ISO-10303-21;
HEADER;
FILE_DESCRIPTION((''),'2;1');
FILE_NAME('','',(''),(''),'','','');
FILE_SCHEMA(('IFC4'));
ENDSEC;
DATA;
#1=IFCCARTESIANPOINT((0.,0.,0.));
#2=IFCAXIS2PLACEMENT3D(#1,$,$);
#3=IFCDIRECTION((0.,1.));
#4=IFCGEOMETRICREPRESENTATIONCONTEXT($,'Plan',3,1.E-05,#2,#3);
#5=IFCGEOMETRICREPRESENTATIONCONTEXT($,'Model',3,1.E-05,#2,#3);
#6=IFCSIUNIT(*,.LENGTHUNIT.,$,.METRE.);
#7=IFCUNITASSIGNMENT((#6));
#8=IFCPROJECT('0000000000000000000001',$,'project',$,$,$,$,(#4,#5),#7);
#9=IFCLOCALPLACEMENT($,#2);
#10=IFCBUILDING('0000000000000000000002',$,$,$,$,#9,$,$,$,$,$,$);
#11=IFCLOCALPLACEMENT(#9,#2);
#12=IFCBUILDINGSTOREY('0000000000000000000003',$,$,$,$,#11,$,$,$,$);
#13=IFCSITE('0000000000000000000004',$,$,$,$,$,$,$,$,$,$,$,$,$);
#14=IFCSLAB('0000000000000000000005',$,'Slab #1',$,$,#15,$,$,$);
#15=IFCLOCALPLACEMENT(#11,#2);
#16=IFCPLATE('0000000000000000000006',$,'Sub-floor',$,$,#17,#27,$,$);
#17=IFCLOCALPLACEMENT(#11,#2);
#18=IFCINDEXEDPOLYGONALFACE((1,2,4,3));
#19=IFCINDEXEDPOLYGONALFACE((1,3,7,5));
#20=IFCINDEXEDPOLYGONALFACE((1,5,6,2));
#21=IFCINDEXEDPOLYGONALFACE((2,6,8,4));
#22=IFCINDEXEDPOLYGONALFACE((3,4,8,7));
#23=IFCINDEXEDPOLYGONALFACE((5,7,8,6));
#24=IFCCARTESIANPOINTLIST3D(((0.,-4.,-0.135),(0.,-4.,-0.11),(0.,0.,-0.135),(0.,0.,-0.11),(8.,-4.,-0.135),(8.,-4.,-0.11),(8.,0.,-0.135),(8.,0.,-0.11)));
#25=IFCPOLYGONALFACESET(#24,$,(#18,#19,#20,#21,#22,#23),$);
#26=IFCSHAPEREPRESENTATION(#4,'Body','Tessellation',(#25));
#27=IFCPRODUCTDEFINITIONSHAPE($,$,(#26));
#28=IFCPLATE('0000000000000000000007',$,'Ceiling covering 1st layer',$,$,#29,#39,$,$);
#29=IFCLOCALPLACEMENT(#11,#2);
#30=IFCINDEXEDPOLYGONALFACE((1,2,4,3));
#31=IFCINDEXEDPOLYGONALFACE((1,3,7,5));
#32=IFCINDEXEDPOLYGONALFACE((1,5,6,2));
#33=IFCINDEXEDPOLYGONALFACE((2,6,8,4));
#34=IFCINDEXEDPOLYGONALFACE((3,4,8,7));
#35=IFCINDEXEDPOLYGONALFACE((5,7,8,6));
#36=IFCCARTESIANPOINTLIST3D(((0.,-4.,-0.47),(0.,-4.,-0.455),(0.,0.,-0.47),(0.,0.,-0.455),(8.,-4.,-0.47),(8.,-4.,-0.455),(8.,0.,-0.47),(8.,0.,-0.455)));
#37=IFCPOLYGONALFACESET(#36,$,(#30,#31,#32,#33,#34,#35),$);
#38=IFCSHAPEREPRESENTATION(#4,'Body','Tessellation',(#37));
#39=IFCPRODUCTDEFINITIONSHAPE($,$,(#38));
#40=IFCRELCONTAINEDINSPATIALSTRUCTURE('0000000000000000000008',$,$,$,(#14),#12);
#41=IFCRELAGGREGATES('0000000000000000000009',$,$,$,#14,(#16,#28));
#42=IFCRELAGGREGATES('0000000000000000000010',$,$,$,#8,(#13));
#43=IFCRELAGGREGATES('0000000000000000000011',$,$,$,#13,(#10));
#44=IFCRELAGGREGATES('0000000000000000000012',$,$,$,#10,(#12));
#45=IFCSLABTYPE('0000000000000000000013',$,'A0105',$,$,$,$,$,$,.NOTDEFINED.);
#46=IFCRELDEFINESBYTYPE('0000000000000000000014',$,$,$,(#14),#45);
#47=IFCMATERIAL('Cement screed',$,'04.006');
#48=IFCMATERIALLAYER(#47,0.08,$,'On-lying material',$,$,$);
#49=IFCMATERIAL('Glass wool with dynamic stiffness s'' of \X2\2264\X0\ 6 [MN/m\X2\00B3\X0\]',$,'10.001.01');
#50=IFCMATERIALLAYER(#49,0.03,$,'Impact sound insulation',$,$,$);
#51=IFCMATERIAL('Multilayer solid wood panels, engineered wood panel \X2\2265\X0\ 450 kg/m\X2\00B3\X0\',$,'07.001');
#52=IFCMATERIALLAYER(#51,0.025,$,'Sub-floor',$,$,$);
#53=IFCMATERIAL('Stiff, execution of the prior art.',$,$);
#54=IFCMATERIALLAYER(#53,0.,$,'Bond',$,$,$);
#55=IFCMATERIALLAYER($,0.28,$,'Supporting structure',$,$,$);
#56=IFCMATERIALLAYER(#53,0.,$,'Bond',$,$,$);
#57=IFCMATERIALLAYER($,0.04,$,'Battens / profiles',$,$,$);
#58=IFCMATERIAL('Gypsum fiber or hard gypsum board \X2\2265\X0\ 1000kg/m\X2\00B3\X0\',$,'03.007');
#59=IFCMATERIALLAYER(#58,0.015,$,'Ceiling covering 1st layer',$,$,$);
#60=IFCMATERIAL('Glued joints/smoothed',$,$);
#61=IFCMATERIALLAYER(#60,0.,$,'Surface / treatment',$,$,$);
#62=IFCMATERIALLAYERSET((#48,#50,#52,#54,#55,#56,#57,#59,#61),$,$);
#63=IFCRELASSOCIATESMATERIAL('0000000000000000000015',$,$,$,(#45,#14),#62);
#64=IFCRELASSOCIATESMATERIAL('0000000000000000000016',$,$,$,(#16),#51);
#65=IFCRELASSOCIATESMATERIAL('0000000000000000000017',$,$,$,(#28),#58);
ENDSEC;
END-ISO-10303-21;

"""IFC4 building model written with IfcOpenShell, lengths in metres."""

from ifc_helpers import new_model, si_unit, direction, frame, frame_2d, origin, place, context, project, spatial, rectangle, extrude, material, layer, layer_set, type_object, element, aggregate, save


model = new_model("IFC4")

# Units and contexts
plan_context = context("Plan", 3, precision=1e-05, world=origin(), true_north=direction((0.0, 1.0)))
model_context = context("Model", 3, precision=1e-05, world=origin(), true_north=direction((0.0, 1.0)))
ifc_project = project(units=[si_unit("LENGTHUNIT", "METRE")], contexts=[plan_context, model_context])

# Site, building, storey
site = spatial("IfcSite", under=ifc_project)
building_placement = place(None, origin())
building = spatial("IfcBuilding", under=site, at=building_placement)
storey_placement = place(building_placement, origin())
storey = spatial("IfcBuildingStorey", under=building, at=storey_placement)

# Slab, plates
ifc_material_1 = material(Name="Cement screed", Category="04.006")
ifc_layer_1 = layer(ifc_material_1, 0.08, Name="On-lying material")
ifc_material_2 = material(Name="Glass wool with dynamic stiffness s' of ≤ 6 [MN/m³]", Category="10.001.01")
ifc_layer_2 = layer(ifc_material_2, 0.03, Name="Impact sound insulation")
ifc_material_3 = material(Name="Multilayer solid wood panels, engineered wood panel ≥ 450 kg/m³", Category="07.001")
ifc_layer_3 = layer(ifc_material_3, 0.025, Name="Sub-floor")
ifc_material_4 = material(Name="Stiff, execution of the prior art.")
ifc_layer_4 = layer(ifc_material_4, 0.0, Name="Bond")
ifc_layer_5 = layer(None, 0.28, Name="Supporting structure")
ifc_layer_6 = layer(ifc_material_4, 0.0, Name="Bond")
ifc_layer_7 = layer(None, 0.04, Name="Battens / profiles")
ifc_material_5 = material(Name="Gypsum fiber or hard gypsum board ≥ 1000kg/m³", Category="03.007")
ifc_layer_8 = layer(ifc_material_5, 0.015, Name="Ceiling covering 1st layer")
ifc_material_6 = material(Name="Glued joints/smoothed")
ifc_layer_9 = layer(ifc_material_6, 0.0, Name="Surface / treatment")
ifc_layer_set = layer_set([ifc_layer_1, ifc_layer_2, ifc_layer_3, ifc_layer_4, ifc_layer_5, ifc_layer_6, ifc_layer_7, ifc_layer_8, ifc_layer_9])
slab_type = type_object("IfcSlabType", Name="A0105", PredefinedType="NOTDEFINED", material=ifc_layer_set)
slab_placement = place(None, frame((0.0, 0.0, 0.0), z_axis=(0.0, 0.0, -1.0), x_axis=(1.0, 0.0, 0.0)))
slab = element("IfcSlab", 1, at=slab_placement, inside=storey, type_object=slab_type, material=ifc_layer_set, Name="Slab #1")
plate_1_placement = place(slab_placement, origin())
plate_1 = element("IfcPlate", 2, at=plate_1_placement, material=ifc_material_3, Name="Sub-floor", context=plan_context, shape_type="SweptSolid", body=[
    extrude(rectangle(XDim=8.0, YDim=4.0, at=frame_2d((4.0, 2.0), x_axis=(1.0, 0.0))), frame((0.0, 0.0, 0.11), z_axis=(0.0, 0.0, 1.0), x_axis=(1.0, 0.0, 0.0)), (0.0, 0.0, 1.0), 0.025),
])
plate_2_placement = place(slab_placement, origin())
plate_2 = element("IfcPlate", 3, at=plate_2_placement, material=ifc_material_5, Name="Ceiling covering 1st layer", context=plan_context, shape_type="SweptSolid", body=[
    extrude(rectangle(XDim=8.0, YDim=4.0, at=frame_2d((4.0, 2.0), x_axis=(1.0, 0.0))), frame((0.0, 0.0, 0.455), z_axis=(0.0, 0.0, 1.0), x_axis=(1.0, 0.0, 0.0)), (0.0, 0.0, 1.0), 0.015),
])
aggregate(slab, [plate_1, plate_2])

save(model, "model.ifc")
